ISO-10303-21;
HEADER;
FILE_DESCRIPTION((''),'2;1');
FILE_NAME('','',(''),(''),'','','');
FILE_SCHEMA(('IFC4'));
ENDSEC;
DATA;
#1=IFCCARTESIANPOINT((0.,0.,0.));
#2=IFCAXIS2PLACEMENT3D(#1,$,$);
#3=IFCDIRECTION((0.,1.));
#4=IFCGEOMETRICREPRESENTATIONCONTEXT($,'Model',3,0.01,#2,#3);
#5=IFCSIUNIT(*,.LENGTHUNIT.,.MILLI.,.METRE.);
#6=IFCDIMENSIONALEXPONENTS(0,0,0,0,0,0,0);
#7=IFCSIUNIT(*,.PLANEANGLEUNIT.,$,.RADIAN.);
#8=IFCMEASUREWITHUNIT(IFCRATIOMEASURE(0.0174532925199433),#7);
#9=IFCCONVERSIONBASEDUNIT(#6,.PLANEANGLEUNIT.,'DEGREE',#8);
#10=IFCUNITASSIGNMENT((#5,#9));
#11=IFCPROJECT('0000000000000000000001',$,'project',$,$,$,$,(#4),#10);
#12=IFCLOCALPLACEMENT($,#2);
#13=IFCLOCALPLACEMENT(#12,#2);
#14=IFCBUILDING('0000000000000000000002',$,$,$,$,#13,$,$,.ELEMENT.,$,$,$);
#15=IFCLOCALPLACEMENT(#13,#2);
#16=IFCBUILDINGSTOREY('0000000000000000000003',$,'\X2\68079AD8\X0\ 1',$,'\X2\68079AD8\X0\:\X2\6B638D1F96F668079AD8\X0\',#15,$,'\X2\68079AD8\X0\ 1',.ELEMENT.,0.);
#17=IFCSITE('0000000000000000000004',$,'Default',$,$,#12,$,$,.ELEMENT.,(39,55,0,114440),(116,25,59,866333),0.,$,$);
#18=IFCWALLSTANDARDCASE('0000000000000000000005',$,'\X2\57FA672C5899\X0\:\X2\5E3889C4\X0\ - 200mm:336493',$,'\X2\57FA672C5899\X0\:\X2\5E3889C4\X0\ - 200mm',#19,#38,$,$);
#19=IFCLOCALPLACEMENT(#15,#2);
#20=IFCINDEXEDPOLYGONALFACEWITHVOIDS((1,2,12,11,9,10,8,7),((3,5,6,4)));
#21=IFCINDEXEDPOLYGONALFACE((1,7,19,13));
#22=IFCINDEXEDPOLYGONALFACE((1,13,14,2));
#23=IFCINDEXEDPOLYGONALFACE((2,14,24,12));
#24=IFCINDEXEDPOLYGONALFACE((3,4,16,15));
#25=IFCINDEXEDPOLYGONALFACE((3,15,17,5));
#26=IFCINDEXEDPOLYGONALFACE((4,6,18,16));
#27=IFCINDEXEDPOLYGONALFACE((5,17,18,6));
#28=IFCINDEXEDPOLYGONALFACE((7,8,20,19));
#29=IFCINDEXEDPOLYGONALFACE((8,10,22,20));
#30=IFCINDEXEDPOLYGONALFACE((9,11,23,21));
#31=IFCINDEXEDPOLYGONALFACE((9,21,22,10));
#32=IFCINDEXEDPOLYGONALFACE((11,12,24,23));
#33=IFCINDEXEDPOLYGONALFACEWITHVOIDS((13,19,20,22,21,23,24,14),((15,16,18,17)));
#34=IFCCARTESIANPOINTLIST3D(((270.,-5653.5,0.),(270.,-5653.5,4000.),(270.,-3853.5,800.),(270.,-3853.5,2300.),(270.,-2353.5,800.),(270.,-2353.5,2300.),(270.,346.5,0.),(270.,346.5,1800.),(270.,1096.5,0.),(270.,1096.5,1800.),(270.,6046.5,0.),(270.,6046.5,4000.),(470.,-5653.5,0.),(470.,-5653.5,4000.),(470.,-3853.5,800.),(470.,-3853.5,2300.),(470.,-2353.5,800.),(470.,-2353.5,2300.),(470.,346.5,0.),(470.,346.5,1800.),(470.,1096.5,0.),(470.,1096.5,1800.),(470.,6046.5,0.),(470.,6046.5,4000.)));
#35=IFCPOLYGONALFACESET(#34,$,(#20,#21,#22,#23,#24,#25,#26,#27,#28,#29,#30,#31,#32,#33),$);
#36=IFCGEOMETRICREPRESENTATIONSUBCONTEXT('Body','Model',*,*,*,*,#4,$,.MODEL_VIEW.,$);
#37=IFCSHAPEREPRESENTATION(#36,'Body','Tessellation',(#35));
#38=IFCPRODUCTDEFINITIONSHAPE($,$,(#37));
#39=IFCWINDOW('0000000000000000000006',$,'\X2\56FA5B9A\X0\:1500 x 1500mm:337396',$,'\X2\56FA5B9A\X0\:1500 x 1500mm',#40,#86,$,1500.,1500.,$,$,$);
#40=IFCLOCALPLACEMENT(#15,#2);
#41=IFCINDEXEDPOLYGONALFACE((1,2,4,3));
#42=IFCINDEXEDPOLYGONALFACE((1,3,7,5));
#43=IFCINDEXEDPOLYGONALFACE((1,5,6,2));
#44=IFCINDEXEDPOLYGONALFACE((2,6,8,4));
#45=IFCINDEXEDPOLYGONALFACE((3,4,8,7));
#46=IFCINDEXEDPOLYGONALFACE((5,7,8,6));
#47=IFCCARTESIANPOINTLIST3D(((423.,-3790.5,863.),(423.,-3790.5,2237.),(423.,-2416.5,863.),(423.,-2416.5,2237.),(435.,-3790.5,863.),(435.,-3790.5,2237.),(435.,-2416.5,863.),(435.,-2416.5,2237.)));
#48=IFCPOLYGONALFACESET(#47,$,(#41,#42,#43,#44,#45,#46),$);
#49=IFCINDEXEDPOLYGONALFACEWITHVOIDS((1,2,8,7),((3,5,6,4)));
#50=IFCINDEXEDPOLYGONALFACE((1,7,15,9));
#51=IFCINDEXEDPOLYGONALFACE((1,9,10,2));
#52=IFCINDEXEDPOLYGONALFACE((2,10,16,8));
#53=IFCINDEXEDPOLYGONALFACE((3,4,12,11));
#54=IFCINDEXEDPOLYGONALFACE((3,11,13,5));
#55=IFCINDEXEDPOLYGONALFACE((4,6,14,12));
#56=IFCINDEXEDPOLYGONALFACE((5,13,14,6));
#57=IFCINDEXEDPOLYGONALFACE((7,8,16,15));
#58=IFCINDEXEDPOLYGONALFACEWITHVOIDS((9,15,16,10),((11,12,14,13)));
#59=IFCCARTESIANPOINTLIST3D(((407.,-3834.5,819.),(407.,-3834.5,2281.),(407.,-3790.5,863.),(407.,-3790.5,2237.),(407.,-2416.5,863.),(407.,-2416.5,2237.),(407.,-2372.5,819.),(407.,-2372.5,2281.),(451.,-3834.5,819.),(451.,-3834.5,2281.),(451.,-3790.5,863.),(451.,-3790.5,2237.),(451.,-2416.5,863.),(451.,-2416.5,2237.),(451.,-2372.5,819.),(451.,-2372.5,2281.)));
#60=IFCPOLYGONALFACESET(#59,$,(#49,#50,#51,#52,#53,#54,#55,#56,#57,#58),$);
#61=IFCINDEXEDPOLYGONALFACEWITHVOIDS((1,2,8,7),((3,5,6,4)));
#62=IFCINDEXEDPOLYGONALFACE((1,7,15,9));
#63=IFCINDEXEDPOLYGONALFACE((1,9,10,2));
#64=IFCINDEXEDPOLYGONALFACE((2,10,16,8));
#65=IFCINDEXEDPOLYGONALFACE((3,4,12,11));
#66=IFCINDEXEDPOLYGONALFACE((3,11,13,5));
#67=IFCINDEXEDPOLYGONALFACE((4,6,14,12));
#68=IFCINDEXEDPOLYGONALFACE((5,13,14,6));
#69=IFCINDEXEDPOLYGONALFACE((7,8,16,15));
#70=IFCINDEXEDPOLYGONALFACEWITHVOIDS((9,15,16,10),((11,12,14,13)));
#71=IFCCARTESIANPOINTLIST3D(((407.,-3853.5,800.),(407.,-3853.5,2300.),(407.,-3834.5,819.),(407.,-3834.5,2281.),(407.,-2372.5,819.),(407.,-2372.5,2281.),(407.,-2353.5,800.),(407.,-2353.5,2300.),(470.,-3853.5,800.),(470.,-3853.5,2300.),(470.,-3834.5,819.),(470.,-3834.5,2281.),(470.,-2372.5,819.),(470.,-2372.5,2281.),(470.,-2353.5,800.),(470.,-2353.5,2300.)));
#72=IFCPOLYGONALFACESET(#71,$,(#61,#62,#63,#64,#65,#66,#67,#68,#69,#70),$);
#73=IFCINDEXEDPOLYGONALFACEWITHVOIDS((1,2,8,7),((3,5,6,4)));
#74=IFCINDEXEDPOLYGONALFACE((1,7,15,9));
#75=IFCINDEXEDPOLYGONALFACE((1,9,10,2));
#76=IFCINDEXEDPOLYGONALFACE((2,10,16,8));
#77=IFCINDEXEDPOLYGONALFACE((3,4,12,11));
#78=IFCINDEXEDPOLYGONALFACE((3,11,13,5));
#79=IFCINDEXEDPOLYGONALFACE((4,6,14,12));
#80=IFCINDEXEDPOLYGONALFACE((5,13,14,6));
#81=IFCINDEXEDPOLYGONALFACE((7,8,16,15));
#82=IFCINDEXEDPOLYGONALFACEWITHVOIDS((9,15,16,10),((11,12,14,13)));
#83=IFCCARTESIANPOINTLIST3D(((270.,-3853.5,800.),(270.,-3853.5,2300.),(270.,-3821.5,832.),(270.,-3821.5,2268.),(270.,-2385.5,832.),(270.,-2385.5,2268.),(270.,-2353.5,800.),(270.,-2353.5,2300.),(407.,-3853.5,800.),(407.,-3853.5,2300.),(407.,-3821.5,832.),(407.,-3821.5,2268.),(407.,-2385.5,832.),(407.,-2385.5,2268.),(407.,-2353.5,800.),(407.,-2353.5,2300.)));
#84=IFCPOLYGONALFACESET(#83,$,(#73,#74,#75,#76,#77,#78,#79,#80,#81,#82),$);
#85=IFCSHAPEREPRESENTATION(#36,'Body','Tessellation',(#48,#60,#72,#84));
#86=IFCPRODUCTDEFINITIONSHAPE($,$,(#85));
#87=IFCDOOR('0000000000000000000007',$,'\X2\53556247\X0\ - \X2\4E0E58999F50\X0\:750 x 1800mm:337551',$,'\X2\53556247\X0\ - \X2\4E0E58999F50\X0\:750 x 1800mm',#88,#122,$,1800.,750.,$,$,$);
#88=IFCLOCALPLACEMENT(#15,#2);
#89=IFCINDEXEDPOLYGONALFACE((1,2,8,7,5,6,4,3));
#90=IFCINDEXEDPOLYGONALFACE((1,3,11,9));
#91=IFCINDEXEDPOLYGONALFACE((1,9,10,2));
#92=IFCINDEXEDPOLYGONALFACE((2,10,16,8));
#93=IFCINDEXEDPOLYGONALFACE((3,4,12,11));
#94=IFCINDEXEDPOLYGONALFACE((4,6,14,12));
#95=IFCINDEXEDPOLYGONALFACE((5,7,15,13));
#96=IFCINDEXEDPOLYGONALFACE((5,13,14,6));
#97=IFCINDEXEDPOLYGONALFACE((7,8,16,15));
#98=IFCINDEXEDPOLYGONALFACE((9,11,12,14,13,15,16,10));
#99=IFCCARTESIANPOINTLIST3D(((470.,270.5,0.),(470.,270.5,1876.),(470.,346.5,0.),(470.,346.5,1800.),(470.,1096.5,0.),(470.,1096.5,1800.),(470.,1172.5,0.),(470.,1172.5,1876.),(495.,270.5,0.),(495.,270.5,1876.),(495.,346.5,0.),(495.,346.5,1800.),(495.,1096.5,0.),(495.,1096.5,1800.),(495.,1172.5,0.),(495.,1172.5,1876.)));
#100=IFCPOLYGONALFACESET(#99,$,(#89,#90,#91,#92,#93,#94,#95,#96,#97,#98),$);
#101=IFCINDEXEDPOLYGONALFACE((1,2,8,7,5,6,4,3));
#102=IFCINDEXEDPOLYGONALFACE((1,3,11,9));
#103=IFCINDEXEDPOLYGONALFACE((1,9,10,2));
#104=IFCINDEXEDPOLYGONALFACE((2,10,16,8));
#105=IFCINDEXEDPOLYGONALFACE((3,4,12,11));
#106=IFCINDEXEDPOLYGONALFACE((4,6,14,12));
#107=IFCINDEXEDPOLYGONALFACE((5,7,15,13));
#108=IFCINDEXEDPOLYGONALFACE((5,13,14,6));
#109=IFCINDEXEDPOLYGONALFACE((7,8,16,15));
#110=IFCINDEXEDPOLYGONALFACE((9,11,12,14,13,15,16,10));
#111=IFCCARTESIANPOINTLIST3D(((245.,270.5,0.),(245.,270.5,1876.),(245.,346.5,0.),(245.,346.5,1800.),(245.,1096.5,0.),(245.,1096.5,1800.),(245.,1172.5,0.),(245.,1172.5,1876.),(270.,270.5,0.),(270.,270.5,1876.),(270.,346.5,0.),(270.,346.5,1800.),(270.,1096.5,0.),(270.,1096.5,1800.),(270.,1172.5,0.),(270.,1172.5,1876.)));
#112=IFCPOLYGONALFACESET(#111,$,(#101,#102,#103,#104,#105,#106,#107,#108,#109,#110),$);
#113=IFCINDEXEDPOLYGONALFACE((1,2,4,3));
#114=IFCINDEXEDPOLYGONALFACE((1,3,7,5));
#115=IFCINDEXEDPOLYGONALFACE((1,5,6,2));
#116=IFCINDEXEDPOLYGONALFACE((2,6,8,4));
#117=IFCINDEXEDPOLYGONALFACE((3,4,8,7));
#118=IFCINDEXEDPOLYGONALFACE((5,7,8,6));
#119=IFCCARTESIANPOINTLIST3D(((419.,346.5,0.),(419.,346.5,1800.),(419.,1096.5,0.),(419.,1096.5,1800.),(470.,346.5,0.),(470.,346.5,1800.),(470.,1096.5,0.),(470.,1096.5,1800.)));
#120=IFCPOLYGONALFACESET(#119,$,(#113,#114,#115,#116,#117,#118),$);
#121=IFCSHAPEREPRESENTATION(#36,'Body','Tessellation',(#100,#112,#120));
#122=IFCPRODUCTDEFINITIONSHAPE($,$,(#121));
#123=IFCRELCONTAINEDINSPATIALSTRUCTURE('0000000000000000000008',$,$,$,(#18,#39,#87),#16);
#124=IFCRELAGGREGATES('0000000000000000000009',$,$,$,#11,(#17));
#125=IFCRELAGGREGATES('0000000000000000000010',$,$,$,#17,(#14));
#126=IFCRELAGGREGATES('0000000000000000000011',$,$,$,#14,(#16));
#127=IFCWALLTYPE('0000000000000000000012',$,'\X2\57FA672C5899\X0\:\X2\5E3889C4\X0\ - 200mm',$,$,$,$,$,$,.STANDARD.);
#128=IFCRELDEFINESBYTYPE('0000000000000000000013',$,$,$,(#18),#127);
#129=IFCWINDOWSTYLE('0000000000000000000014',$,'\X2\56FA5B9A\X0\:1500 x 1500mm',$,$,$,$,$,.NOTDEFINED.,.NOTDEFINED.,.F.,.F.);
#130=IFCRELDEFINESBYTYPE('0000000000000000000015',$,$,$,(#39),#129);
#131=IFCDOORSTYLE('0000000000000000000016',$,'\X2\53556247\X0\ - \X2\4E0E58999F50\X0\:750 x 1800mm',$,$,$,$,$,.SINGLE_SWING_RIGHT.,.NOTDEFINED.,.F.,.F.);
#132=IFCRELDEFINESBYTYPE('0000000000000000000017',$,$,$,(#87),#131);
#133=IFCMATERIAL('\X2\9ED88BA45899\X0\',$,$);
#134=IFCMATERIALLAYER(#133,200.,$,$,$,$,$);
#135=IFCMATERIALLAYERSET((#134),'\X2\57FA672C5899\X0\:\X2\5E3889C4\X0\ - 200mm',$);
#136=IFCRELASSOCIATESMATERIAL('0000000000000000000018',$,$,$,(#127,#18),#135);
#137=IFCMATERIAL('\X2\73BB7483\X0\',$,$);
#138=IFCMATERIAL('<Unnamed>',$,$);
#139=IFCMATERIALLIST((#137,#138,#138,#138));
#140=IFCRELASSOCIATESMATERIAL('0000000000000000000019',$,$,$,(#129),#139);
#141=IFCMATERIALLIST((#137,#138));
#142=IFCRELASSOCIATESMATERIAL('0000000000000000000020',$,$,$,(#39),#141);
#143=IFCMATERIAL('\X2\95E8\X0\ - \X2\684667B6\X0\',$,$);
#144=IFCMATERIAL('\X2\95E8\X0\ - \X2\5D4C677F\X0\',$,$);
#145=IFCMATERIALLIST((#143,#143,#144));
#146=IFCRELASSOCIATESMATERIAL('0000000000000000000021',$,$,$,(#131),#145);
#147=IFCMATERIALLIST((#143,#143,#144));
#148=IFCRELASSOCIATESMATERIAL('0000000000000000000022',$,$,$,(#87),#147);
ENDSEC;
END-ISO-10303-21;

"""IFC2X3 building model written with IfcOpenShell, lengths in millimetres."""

from ifc_helpers import new_model, entity, si_unit, converted_unit, direction, frame, frame_2d, origin, place, context, subcontext, project, spatial, polyline, rectangle, outline, extrude, source, transform, mapped, material, material_list, layer, layer_set, layer_usage, type_object, type_shapes, element, fill, save


model = new_model("IFC2X3")

# Units and contexts
model_context = context("Model", 3, precision=0.01, world=origin(), true_north=direction((0.0, 1.0)))
body_context = subcontext(model_context, "Body", "Model", "MODEL_VIEW")
ifc_project = project(units=[si_unit("LENGTHUNIT", "METRE", prefix="MILLI"), converted_unit("PLANEANGLEUNIT", "DEGREE", entity("IfcRatioMeasure", 0.0174532925199433), si_unit("PLANEANGLEUNIT", "RADIAN"), dimensions=[0, 0, 0, 0, 0, 0, 0])], contexts=[model_context])

# Site, building, storey
site_placement = place(None, origin())
site = spatial("IfcSite", under=ifc_project, at=site_placement, Name="Default", CompositionType="ELEMENT", RefLatitude=(39, 55, 0, 114440), RefLongitude=(116, 25, 59, 866333), RefElevation=0.0)
building_placement = place(site_placement, origin())
building = spatial("IfcBuilding", under=site, at=building_placement, CompositionType="ELEMENT")
storey_placement = place(building_placement, origin())
storey = spatial("IfcBuildingStorey", under=building, at=storey_placement, Name="标高 1", ObjectType="标高:正负零标高", LongName="标高 1", CompositionType="ELEMENT", Elevation=0.0)

# Wall, openings, window, door
ifc_material_1 = material(Name="默认墙")
ifc_layer = layer(ifc_material_1, 200.0)
ifc_layer_set = layer_set([ifc_layer], Name="基本墙:常规 - 200mm")
ifc_layer_usage_1 = layer_usage(ifc_layer_set, "AXIS2", "NEGATIVE", 100.0)
wall_type = type_object("IfcWallType", Name="基本墙:常规 - 200mm", PredefinedType="STANDARD", material=ifc_layer_set)
wall_1_placement = place(storey_placement, frame((370.0, -5653.5, 0.0), z_axis=(0.0, 0.0, 1.0), x_axis=(0.0, 1.0, 0.0)))
wall_1 = element("IfcWallStandardCase", 1, at=wall_1_placement, inside=storey, type_object=wall_type, material=ifc_layer_usage_1, Name="基本墙:常规 - 200mm:336493", ObjectType="基本墙:常规 - 200mm", context=body_context, shape_type="SweptSolid", body=[
    extrude(rectangle(XDim=11700.0, YDim=200.0, at=frame_2d((5850.0, 0.0), x_axis=(-1.0, 0.0))), origin(), (0.0, 0.0, 1.0), 4000.0),
])
opening_1_placement = place(wall_1_placement, frame((6750.0, 100.0, 0.0)))
opening_1 = element("IfcOpeningElement", 2, at=opening_1_placement, cuts=wall_1, ObjectType="Opening", context=body_context, shape_type="SweptSolid", body=[
    extrude(rectangle(XDim=750.0, YDim=1800.0, at=frame_2d((900.0, 375.0), x_axis=(0.0, 1.0))), frame((0.0, 0.0, 0.0), z_axis=(0.0, -1.0, 0.0), x_axis=(0.0, 0.0, 1.0)), (0.0, 0.0, 1.0), 200.0),
])
opening_2_placement = place(wall_1_placement, frame((3300.0, 100.0, 800.0)))
opening_2 = element("IfcOpeningElement", 3, at=opening_2_placement, cuts=wall_1, ObjectType="Opening", context=body_context, shape_type="SweptSolid", body=[
    extrude(rectangle(XDim=1500.0, YDim=1500.0, at=frame_2d((750.0, 750.0), x_axis=(1.0, 0.0))), frame((0.0, 0.0, 0.0), z_axis=(0.0, -1.0, 0.0), x_axis=(0.0, 0.0, 1.0)), (0.0, 0.0, 1.0), 200.0),
])
ifc_material_2 = material(Name="玻璃")
ifc_material_3 = material(Name="<Unnamed>")
ifc_material_list_1 = material_list([ifc_material_2, ifc_material_3])
ifc_material_list_2 = material_list([ifc_material_2, ifc_material_3, ifc_material_3, ifc_material_3])
window_style_1 = type_object("IfcWindowStyle", Name="固定:1500 x 1500mm", ConstructionType="NOTDEFINED", OperationType="NOTDEFINED", ParameterTakesPrecedence=False, Sizeable=False, material=ifc_material_list_2)
shared_shape_1 = source(origin(), body_context, "Body", "SweptSolid", [
    extrude(rectangle(XDim=12.0, YDim=1374.0, at=frame_2d((0.0, 0.0), x_axis=(1.0, 0.0))), frame((750.0, 159.0, 63.0), z_axis=(0.0, 0.0, 1.0), x_axis=(0.0, -1.0, 0.0)), (0.0, 0.0, 1.0), 1374.0),
    extrude(outline(polyline([(-731.0, -731.0), (731.0, -731.0), (731.0, 731.0), (-731.0, 731.0), (-731.0, -731.0)]), holes=[polyline([(-687.0, -687.0), (-687.0, 687.0), (687.0, 687.0), (687.0, -687.0), (-687.0, -687.0)])]), frame((750.0, 137.0, 750.0), z_axis=(0.0, 1.0, 0.0), x_axis=(1.0, 0.0, 0.0)), (0.0, 0.0, 1.0), 44.0),
    extrude(outline(polyline([(-750.0, -750.0), (750.0, -750.0), (750.0, 750.0), (-750.0, 750.0), (-750.0, -750.0)]), holes=[polyline([(-731.0, -731.0), (-731.0, 731.0), (731.0, 731.0), (731.0, -731.0), (-731.0, -731.0)])]), frame((750.0, 137.0, 750.0), z_axis=(0.0, 1.0, 0.0), x_axis=(1.0, 0.0, 0.0)), (0.0, 0.0, 1.0), 63.0),
    extrude(outline(polyline([(-750.0, -750.0), (750.0, -750.0), (750.0, 750.0), (-750.0, 750.0), (-750.0, -750.0)]), holes=[polyline([(-718.0, -718.0), (-718.0, 718.0), (718.0, 718.0), (718.0, -718.0), (-718.0, -718.0)])]), frame((750.0, 0.0, 750.0), z_axis=(0.0, 1.0, 0.0), x_axis=(1.0, 0.0, 0.0)), (0.0, 0.0, 1.0), 137.0),
])
type_shapes(window_style_1, [shared_shape_1])
window_1_placement = place(opening_2_placement, frame((0.0, 0.0, 0.0), z_axis=(0.0, 0.0, 1.0), x_axis=(-1.0, 0.0, 0.0)))
window_1 = element("IfcWindow", 4, at=window_1_placement, inside=storey, type_object=window_style_1, material=ifc_material_list_1, Name="固定:1500 x 1500mm:337396", ObjectType="固定:1500 x 1500mm", OverallHeight=1500.0, OverallWidth=1500.0, context=body_context, shape_type="MappedRepresentation", body=[
    mapped(shared_shape_1, transform((0.0, 0.0, 0.0), scale=1.0)),
])
fill(opening_2, window_1)
ifc_material_4 = material(Name="门 - 框架")
ifc_material_5 = material(Name="门 - 嵌板")
ifc_material_list_3 = material_list([ifc_material_4, ifc_material_4, ifc_material_5])
ifc_material_list_4 = material_list([ifc_material_4, ifc_material_4, ifc_material_5])
door_style_1 = type_object("IfcDoorStyle", Name="单扇 - 与墙齐:750 x 1800mm", ConstructionType="NOTDEFINED", OperationType="SINGLE_SWING_RIGHT", ParameterTakesPrecedence=False, Sizeable=False, material=ifc_material_list_4)
shared_shape_2 = source(origin(), body_context, "Body", "SweptSolid", [
    extrude(outline(polyline([(-451.0, -957.0), (451.0, -957.0), (451.0, 919.0), (375.0, 919.0), (375.0, -881.0), (-375.0, -881.0), (-375.0, 919.0), (-451.0, 919.0), (-451.0, -957.0)])), frame((375.0, 200.0, 919.0), z_axis=(0.0, 1.0, 0.0), x_axis=(1.0, 0.0, 0.0)), (0.0, 0.0, 1.0), 25.0),
    extrude(outline(polyline([(-957.0, -451.0), (919.0, -451.0), (919.0, -375.0), (-881.0, -375.0), (-881.0, 375.0), (919.0, 375.0), (919.0, 451.0), (-957.0, 451.0), (-957.0, -451.0)])), frame((375.0, -25.0, 919.0), z_axis=(0.0, 1.0, 0.0), x_axis=(0.0, 0.0, -1.0)), (0.0, 0.0, 1.0), 25.0),
    extrude(rectangle(XDim=51.0, YDim=750.0, at=frame_2d((0.0, 0.0), x_axis=(1.0, 0.0))), frame((375.0, 174.5, 0.0), z_axis=(0.0, 0.0, 1.0), x_axis=(0.0, 1.0, 0.0)), (0.0, 0.0, 1.0), 1800.0),
])
type_shapes(door_style_1, [shared_shape_2])
door_1_placement = place(opening_1_placement, frame((0.0, 0.0, 0.0), z_axis=(0.0, 0.0, 1.0), x_axis=(-1.0, 0.0, 0.0)))
door_1 = element("IfcDoor", 5, at=door_1_placement, inside=storey, type_object=door_style_1, material=ifc_material_list_3, Name="单扇 - 与墙齐:750 x 1800mm:337551", ObjectType="单扇 - 与墙齐:750 x 1800mm", OverallHeight=1800.0, OverallWidth=750.0, context=body_context, shape_type="MappedRepresentation", body=[
    mapped(shared_shape_2, transform((0.0, 0.0, 0.0), scale=1.0)),
])
fill(opening_1, door_1)

save(model, "model.ifc")
